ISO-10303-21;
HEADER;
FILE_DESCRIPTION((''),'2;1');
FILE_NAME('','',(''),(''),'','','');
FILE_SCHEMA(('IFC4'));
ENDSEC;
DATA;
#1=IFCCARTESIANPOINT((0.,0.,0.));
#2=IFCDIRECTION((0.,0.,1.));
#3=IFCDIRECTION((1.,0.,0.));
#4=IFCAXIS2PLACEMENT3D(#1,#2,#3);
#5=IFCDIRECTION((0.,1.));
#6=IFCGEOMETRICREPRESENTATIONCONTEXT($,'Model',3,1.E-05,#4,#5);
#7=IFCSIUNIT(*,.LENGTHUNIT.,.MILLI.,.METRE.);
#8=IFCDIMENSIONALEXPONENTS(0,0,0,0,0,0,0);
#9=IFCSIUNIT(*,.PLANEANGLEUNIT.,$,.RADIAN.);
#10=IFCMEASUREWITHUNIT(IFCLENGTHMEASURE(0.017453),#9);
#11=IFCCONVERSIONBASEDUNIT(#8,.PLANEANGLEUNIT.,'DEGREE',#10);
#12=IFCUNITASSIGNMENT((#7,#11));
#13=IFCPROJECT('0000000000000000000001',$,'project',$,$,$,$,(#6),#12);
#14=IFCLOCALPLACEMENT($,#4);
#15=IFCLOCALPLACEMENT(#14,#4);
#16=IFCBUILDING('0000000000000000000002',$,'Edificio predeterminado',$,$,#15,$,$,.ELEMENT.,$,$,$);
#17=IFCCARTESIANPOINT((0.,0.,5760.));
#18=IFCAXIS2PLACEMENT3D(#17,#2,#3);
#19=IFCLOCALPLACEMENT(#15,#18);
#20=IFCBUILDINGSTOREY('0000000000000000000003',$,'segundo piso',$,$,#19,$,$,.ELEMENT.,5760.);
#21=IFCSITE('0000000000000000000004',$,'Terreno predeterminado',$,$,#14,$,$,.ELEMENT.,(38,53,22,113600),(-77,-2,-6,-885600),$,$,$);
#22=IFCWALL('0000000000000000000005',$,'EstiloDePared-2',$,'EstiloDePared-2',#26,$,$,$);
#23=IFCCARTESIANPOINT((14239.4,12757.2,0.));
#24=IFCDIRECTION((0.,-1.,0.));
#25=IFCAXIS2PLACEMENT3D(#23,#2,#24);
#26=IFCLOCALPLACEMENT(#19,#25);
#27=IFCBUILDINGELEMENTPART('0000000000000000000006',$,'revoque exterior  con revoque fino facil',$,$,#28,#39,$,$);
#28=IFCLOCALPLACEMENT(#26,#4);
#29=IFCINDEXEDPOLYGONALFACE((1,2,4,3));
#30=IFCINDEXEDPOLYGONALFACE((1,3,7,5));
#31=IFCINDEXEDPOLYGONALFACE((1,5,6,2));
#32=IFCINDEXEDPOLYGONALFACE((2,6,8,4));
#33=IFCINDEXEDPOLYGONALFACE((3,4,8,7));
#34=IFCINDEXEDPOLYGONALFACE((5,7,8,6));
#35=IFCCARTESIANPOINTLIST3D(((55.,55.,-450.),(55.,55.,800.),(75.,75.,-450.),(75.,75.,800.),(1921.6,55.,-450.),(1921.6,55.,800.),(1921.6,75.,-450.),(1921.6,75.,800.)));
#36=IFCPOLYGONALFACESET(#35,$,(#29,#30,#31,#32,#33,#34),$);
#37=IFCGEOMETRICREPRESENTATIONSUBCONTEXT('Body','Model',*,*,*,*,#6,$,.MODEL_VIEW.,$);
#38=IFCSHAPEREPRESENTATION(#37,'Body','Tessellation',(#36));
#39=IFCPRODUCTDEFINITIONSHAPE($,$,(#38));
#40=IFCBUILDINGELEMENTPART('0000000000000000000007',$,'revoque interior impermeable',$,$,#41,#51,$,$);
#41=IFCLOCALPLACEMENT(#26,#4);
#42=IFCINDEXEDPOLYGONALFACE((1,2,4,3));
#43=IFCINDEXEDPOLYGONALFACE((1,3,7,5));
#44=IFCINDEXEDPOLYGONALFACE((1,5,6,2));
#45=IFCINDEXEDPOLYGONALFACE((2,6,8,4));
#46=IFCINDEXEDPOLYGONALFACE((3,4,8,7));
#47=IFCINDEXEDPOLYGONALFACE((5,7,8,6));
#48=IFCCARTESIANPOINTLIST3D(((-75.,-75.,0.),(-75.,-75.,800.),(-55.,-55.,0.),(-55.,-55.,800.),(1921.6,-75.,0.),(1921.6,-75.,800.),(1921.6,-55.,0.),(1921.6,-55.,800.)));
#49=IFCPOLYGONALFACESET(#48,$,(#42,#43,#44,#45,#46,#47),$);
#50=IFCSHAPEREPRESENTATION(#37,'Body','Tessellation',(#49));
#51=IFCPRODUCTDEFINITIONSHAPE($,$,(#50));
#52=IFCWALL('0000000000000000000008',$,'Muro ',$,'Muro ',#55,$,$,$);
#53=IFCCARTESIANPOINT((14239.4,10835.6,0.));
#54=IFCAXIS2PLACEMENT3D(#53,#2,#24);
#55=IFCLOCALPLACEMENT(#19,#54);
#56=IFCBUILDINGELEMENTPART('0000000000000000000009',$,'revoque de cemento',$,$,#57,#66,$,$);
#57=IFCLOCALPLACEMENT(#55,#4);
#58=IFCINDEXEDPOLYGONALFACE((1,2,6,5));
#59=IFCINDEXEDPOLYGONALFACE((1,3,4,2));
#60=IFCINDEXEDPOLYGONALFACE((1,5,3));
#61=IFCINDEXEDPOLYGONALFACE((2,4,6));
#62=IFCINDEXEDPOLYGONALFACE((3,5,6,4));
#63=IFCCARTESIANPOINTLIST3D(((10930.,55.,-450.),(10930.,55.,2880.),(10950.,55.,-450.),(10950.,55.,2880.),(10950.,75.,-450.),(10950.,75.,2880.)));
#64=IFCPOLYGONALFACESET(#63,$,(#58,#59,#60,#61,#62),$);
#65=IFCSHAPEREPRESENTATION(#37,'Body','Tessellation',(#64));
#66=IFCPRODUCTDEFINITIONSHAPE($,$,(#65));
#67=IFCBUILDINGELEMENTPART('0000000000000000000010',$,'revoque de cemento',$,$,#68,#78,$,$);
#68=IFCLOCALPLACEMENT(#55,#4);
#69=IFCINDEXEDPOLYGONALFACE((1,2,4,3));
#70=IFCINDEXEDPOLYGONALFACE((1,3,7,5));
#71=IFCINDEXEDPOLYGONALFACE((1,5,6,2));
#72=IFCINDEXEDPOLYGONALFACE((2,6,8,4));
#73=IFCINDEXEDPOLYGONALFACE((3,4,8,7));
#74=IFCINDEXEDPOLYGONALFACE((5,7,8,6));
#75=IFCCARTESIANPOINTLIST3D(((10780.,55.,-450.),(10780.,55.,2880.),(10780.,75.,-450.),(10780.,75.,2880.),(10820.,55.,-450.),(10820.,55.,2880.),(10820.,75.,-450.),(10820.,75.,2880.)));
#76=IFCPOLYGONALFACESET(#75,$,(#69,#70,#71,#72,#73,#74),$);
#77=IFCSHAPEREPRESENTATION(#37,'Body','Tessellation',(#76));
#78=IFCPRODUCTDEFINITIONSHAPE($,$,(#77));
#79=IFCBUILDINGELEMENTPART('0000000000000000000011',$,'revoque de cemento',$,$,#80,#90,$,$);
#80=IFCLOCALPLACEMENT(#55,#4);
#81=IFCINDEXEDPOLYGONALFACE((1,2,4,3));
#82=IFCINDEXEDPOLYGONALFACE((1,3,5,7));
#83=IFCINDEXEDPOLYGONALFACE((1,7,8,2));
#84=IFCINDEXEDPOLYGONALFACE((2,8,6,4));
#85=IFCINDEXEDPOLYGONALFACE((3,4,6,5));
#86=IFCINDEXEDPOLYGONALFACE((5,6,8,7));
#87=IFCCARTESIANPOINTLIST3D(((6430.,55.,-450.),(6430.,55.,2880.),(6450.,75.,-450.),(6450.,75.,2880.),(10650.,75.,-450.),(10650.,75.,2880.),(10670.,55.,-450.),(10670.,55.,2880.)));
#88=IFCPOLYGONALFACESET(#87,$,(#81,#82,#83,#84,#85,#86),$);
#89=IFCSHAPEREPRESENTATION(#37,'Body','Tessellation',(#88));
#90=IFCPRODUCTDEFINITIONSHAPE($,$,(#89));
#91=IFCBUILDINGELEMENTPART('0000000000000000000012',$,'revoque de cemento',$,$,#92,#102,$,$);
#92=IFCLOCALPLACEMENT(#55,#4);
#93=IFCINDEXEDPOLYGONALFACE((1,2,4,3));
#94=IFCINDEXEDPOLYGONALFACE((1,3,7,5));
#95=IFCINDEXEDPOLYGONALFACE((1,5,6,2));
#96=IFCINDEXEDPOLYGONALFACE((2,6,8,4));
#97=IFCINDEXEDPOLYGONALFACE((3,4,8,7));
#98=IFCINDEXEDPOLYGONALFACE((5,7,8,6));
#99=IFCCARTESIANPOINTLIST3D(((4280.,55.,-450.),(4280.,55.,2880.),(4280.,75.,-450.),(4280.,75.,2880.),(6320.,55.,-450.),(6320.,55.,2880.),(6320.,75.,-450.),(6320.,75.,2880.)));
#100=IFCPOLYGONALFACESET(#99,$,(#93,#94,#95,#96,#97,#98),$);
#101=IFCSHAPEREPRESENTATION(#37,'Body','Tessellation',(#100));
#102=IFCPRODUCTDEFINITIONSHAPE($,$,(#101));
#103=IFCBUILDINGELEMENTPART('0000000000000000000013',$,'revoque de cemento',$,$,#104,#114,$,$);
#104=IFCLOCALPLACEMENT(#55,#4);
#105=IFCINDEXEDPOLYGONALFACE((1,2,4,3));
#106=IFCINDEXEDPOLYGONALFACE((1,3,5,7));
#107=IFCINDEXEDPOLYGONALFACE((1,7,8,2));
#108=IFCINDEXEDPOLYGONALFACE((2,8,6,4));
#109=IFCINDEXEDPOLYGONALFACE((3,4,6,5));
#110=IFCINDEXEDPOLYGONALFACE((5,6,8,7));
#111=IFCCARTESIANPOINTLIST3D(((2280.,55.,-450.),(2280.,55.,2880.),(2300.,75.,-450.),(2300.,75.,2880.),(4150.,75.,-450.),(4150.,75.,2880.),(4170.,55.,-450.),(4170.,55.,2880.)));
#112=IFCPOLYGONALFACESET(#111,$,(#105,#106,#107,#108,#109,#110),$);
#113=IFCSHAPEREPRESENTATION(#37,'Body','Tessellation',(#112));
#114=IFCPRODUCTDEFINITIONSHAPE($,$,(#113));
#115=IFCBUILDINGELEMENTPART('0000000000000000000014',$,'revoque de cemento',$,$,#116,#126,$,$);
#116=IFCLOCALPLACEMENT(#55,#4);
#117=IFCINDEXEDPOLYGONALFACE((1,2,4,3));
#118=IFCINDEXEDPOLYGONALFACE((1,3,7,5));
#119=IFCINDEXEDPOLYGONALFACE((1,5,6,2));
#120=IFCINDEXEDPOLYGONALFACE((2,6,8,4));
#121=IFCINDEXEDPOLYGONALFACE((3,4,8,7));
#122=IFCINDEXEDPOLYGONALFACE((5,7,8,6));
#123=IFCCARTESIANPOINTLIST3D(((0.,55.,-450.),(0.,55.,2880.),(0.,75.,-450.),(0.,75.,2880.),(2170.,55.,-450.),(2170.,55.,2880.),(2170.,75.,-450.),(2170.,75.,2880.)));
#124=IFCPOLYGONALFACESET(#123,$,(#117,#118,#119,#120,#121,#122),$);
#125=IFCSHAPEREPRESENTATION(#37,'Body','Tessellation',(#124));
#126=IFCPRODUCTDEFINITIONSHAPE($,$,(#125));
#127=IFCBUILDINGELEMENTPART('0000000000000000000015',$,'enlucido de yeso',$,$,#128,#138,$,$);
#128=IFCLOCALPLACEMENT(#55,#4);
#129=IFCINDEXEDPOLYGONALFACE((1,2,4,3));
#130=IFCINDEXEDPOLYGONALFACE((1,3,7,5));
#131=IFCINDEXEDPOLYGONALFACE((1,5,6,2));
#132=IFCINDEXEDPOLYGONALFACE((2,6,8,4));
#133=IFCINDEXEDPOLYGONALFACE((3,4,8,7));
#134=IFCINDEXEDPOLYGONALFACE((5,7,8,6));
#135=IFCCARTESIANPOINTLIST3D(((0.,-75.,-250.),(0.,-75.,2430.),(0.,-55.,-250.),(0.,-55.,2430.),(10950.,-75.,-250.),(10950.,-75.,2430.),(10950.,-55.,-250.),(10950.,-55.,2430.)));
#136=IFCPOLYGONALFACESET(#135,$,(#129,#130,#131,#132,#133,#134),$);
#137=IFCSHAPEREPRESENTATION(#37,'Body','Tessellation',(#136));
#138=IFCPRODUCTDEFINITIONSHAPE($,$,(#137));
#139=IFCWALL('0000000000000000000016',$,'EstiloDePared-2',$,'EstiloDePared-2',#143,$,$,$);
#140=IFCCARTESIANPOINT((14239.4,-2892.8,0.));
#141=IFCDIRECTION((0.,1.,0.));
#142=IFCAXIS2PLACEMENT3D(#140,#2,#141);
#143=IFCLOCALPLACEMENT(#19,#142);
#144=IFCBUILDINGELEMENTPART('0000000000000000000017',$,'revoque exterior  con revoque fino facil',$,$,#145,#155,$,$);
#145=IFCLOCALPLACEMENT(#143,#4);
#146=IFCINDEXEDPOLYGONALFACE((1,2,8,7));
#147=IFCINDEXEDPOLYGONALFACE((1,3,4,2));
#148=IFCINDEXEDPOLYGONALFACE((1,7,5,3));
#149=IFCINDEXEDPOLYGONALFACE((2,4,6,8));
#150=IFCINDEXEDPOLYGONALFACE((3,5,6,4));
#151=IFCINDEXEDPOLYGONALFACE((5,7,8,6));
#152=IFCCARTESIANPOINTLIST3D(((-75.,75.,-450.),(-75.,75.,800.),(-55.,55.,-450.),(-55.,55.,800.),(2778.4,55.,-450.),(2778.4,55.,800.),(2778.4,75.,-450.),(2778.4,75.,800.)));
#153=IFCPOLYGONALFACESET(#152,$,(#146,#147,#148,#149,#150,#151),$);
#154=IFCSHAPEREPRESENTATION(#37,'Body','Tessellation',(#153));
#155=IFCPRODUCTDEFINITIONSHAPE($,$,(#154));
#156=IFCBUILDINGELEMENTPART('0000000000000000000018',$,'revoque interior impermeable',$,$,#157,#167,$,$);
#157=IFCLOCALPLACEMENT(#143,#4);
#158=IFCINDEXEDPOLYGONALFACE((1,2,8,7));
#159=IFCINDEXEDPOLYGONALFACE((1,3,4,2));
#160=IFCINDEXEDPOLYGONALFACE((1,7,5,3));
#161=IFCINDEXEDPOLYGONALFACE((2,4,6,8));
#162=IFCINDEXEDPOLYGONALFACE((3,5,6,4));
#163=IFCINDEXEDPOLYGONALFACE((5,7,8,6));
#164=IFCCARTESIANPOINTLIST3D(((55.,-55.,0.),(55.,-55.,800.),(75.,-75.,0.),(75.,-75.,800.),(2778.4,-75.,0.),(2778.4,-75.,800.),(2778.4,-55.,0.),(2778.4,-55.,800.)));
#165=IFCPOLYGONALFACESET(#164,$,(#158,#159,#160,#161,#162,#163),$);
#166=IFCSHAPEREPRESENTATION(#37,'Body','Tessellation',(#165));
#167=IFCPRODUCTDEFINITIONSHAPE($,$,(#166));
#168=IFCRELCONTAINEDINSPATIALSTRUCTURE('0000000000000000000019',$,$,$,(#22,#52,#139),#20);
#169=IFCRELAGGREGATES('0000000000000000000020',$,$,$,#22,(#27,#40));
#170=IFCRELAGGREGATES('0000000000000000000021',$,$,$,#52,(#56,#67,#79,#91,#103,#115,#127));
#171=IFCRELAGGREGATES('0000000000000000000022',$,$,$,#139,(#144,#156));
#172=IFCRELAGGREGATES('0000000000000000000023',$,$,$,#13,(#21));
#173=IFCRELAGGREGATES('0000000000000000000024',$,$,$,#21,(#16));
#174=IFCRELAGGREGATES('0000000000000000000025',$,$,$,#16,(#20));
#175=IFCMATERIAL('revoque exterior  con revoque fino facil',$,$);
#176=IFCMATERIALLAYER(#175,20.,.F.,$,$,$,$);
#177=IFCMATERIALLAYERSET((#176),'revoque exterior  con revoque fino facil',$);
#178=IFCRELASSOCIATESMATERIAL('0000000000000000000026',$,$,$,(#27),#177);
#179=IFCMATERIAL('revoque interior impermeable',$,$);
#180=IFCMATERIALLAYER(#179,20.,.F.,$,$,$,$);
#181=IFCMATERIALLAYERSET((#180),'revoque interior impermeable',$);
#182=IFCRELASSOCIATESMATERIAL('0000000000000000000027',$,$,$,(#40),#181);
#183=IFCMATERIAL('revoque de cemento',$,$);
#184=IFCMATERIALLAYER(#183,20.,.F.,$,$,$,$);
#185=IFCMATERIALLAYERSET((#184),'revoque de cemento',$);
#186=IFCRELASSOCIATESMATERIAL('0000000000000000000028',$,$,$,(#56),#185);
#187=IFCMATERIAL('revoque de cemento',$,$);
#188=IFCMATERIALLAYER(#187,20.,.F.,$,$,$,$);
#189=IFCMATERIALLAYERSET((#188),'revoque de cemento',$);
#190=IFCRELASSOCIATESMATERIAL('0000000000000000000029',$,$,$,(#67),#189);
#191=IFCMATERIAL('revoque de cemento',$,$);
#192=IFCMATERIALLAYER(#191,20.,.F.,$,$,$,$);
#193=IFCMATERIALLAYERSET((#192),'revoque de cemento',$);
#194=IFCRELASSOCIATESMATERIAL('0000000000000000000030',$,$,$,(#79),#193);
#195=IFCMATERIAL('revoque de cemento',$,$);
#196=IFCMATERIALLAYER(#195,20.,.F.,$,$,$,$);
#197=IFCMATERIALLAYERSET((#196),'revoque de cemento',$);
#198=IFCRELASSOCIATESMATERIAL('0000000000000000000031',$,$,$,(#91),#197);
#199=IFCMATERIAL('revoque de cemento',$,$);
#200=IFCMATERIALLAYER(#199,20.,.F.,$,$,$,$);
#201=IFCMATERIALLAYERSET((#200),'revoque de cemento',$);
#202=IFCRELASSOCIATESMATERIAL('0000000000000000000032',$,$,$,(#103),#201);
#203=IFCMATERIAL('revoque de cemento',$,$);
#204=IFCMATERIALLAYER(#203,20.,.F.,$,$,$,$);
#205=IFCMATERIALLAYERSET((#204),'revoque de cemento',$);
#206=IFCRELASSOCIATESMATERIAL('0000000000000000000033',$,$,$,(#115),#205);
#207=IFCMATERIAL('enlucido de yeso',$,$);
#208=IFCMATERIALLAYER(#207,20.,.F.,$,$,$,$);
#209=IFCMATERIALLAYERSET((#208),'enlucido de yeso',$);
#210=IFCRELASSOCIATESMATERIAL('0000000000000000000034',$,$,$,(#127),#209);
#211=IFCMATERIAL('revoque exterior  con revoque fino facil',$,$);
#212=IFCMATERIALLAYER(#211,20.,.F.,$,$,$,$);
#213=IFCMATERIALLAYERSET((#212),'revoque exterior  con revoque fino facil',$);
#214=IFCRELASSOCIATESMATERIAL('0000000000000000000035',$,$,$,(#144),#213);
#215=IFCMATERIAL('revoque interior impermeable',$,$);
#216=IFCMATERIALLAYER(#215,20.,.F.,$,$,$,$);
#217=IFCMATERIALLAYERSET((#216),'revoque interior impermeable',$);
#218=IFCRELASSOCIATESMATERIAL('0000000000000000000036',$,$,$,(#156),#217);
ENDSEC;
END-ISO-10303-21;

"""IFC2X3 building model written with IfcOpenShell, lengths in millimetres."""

from ifc_helpers import new_model, entity, si_unit, converted_unit, direction, frame, origin_with_axes, place, context, subcontext, project, spatial, polyline, outline, extrude, material, layer, layer_set, layer_usage, element, aggregate, save


model = new_model("IFC2X3")

# Units and contexts
model_context = context("Model", 3, precision=1e-05, world=origin_with_axes(), true_north=direction((0.0, 1.0)))
body_context = subcontext(model_context, "Body", "Model", "MODEL_VIEW")
ifc_project = project(units=[si_unit("LENGTHUNIT", "METRE", prefix="MILLI"), converted_unit("PLANEANGLEUNIT", "DEGREE", entity("IfcLengthMeasure", 0.017453), si_unit("PLANEANGLEUNIT", "RADIAN"), dimensions=[0, 0, 0, 0, 0, 0, 0])], contexts=[model_context])

# Site, building, storey
site_placement = place(None, origin_with_axes())
site = spatial("IfcSite", under=ifc_project, at=site_placement, Name="Terreno predeterminado", CompositionType="ELEMENT", RefLatitude=(38, 53, 22, 113600), RefLongitude=(-77, -2, -6, -885600))
building_placement = place(site_placement, origin_with_axes())
building = spatial("IfcBuilding", under=site, at=building_placement, Name="Edificio predeterminado", CompositionType="ELEMENT")
storey_placement = place(building_placement, frame((0.0, 0.0, 5760.0), z_axis=(0.0, 0.0, 1.0), x_axis=(1.0, 0.0, 0.0)))
storey = spatial("IfcBuildingStorey", under=building, at=storey_placement, Name="segundo piso", CompositionType="ELEMENT", Elevation=5760.0)

# Walls, building element parts
wall_1_placement = place(storey_placement, frame((14239.4, 12757.2, 0.0), z_axis=(0.0, 0.0, 1.0), x_axis=(0.0, -1.0, 0.0)))
wall_1 = element("IfcWall", 1, at=wall_1_placement, inside=storey, Name="EstiloDePared-2", ObjectType="EstiloDePared-2")
ifc_material_1 = material(Name="revoque exterior  con revoque fino facil")
ifc_layer_1 = layer(ifc_material_1, 20.0, ventilated=False)
ifc_layer_set_1 = layer_set([ifc_layer_1], Name="revoque exterior  con revoque fino facil")
ifc_layer_usage_1 = layer_usage(ifc_layer_set_1, "AXIS2", "NEGATIVE", -75.0)
building_element_part_1_placement = place(wall_1_placement, origin_with_axes())
building_element_part_1 = element("IfcBuildingElementPart", 2, at=building_element_part_1_placement, material=ifc_layer_usage_1, Name="revoque exterior  con revoque fino facil", context=body_context, shape_type="SweptSolid", body=[
    extrude(outline(polyline([(1921.6, 75.0), (1921.6, 55.0), (55.0, 55.0), (75.0, 75.0), (1921.6, 75.0)])), frame((0.0, 0.0, -450.0), z_axis=(0.0, 0.0, 1.0), x_axis=(1.0, 0.0, 0.0)), (0.0, 0.0, 1.0), 1250.0),
])
ifc_material_2 = material(Name="revoque interior impermeable")
ifc_layer_2 = layer(ifc_material_2, 20.0, ventilated=False)
ifc_layer_set_2 = layer_set([ifc_layer_2], Name="revoque interior impermeable")
ifc_layer_usage_2 = layer_usage(ifc_layer_set_2, "AXIS2", "NEGATIVE", 55.0)
building_element_part_2_placement = place(wall_1_placement, origin_with_axes())
building_element_part_2 = element("IfcBuildingElementPart", 3, at=building_element_part_2_placement, material=ifc_layer_usage_2, Name="revoque interior impermeable", context=body_context, shape_type="SweptSolid", body=[
    extrude(outline(polyline([(1921.6, -55.0), (1921.6, -75.0), (-75.0, -75.0), (-55.0, -55.0), (1921.6, -55.0)])), origin_with_axes(), (0.0, 0.0, 1.0), 800.0),
])
aggregate(wall_1, [building_element_part_1, building_element_part_2])
wall_2_placement = place(storey_placement, frame((14239.4, 10835.6, 0.0), z_axis=(0.0, 0.0, 1.0), x_axis=(0.0, -1.0, 0.0)))
wall_2 = element("IfcWall", 4, at=wall_2_placement, inside=storey, Name="Muro ", ObjectType="Muro ")
ifc_material_3 = material(Name="revoque de cemento")
ifc_layer_3 = layer(ifc_material_3, 20.0, ventilated=False)
ifc_layer_set_3 = layer_set([ifc_layer_3], Name="revoque de cemento")
ifc_layer_usage_3 = layer_usage(ifc_layer_set_3, "AXIS2", "NEGATIVE", -75.0)
building_element_part_3_placement = place(wall_2_placement, origin_with_axes())
building_element_part_3 = element("IfcBuildingElementPart", 5, at=building_element_part_3_placement, material=ifc_layer_usage_3, Name="revoque de cemento", context=body_context, shape_type="SweptSolid", body=[
    extrude(outline(polyline([(10950.0, 75.0), (10950.0, 55.0), (10930.0, 55.0), (10950.0, 75.0)])), frame((0.0, 0.0, -450.0), z_axis=(0.0, 0.0, 1.0), x_axis=(1.0, 0.0, 0.0)), (0.0, 0.0, 1.0), 3330.0),
])
ifc_material_4 = material(Name="revoque de cemento")
ifc_layer_4 = layer(ifc_material_4, 20.0, ventilated=False)
ifc_layer_set_4 = layer_set([ifc_layer_4], Name="revoque de cemento")
ifc_layer_usage_4 = layer_usage(ifc_layer_set_4, "AXIS2", "NEGATIVE", -75.0)
building_element_part_4_placement = place(wall_2_placement, origin_with_axes())
building_element_part_4 = element("IfcBuildingElementPart", 6, at=building_element_part_4_placement, material=ifc_layer_usage_4, Name="revoque de cemento", context=body_context, shape_type="SweptSolid", body=[
    extrude(outline(polyline([(10820.0, 75.0), (10820.0, 55.0), (10780.0, 55.0), (10780.0, 75.0), (10820.0, 75.0)])), frame((0.0, 0.0, -450.0), z_axis=(0.0, 0.0, 1.0), x_axis=(1.0, 0.0, 0.0)), (0.0, 0.0, 1.0), 3330.0),
])
ifc_material_5 = material(Name="revoque de cemento")
ifc_layer_5 = layer(ifc_material_5, 20.0, ventilated=False)
ifc_layer_set_5 = layer_set([ifc_layer_5], Name="revoque de cemento")
ifc_layer_usage_5 = layer_usage(ifc_layer_set_5, "AXIS2", "NEGATIVE", -75.0)
building_element_part_5_placement = place(wall_2_placement, origin_with_axes())
building_element_part_5 = element("IfcBuildingElementPart", 7, at=building_element_part_5_placement, material=ifc_layer_usage_5, Name="revoque de cemento", context=body_context, shape_type="SweptSolid", body=[
    extrude(outline(polyline([(10650.0, 75.0), (10670.0, 55.0), (6430.0, 55.0), (6450.0, 75.0), (10650.0, 75.0)])), frame((0.0, 0.0, -450.0), z_axis=(0.0, 0.0, 1.0), x_axis=(1.0, 0.0, 0.0)), (0.0, 0.0, 1.0), 3330.0),
])
ifc_material_6 = material(Name="revoque de cemento")
ifc_layer_6 = layer(ifc_material_6, 20.0, ventilated=False)
ifc_layer_set_6 = layer_set([ifc_layer_6], Name="revoque de cemento")
ifc_layer_usage_6 = layer_usage(ifc_layer_set_6, "AXIS2", "NEGATIVE", -75.0)
building_element_part_6_placement = place(wall_2_placement, origin_with_axes())
building_element_part_6 = element("IfcBuildingElementPart", 8, at=building_element_part_6_placement, material=ifc_layer_usage_6, Name="revoque de cemento", context=body_context, shape_type="SweptSolid", body=[
    extrude(outline(polyline([(4280.0, 75.0), (6320.0, 75.0), (6320.0, 55.0), (4280.0, 55.0), (4280.0, 75.0)])), frame((0.0, 0.0, -450.0), z_axis=(0.0, 0.0, 1.0), x_axis=(1.0, 0.0, 0.0)), (0.0, 0.0, 1.0), 3330.0),
])
ifc_material_7 = material(Name="revoque de cemento")
ifc_layer_7 = layer(ifc_material_7, 20.0, ventilated=False)
ifc_layer_set_7 = layer_set([ifc_layer_7], Name="revoque de cemento")
ifc_layer_usage_7 = layer_usage(ifc_layer_set_7, "AXIS2", "NEGATIVE", -75.0)
building_element_part_7_placement = place(wall_2_placement, origin_with_axes())
building_element_part_7 = element("IfcBuildingElementPart", 9, at=building_element_part_7_placement, material=ifc_layer_usage_7, Name="revoque de cemento", context=body_context, shape_type="SweptSolid", body=[
    extrude(outline(polyline([(4150.0, 75.0), (4170.0, 55.0), (2280.0, 55.0), (2300.0, 75.0), (4150.0, 75.0)])), frame((0.0, 0.0, -450.0), z_axis=(0.0, 0.0, 1.0), x_axis=(1.0, 0.0, 0.0)), (0.0, 0.0, 1.0), 3330.0),
])
ifc_material_8 = material(Name="revoque de cemento")
ifc_layer_8 = layer(ifc_material_8, 20.0, ventilated=False)
ifc_layer_set_8 = layer_set([ifc_layer_8], Name="revoque de cemento")
ifc_layer_usage_8 = layer_usage(ifc_layer_set_8, "AXIS2", "NEGATIVE", -75.0)
building_element_part_8_placement = place(wall_2_placement, origin_with_axes())
building_element_part_8 = element("IfcBuildingElementPart", 10, at=building_element_part_8_placement, material=ifc_layer_usage_8, Name="revoque de cemento", context=body_context, shape_type="SweptSolid", body=[
    extrude(outline(polyline([(2170.0, 75.0), (2170.0, 55.0), (0.0, 55.0), (0.0, 75.0), (2170.0, 75.0)])), frame((0.0, 0.0, -450.0), z_axis=(0.0, 0.0, 1.0), x_axis=(1.0, 0.0, 0.0)), (0.0, 0.0, 1.0), 3330.0),
])
ifc_material_9 = material(Name="enlucido de yeso")
ifc_layer_9 = layer(ifc_material_9, 20.0, ventilated=False)
ifc_layer_set_9 = layer_set([ifc_layer_9], Name="enlucido de yeso")
ifc_layer_usage_9 = layer_usage(ifc_layer_set_9, "AXIS2", "NEGATIVE", 55.0)
building_element_part_9_placement = place(wall_2_placement, origin_with_axes())
building_element_part_9 = element("IfcBuildingElementPart", 11, at=building_element_part_9_placement, material=ifc_layer_usage_9, Name="enlucido de yeso", context=body_context, shape_type="SweptSolid", body=[
    extrude(outline(polyline([(10950.0, -55.0), (10950.0, -75.0), (0.0, -75.0), (0.0, -55.0), (10950.0, -55.0)])), frame((0.0, 0.0, -250.0), z_axis=(0.0, 0.0, 1.0), x_axis=(1.0, 0.0, 0.0)), (0.0, 0.0, 1.0), 2680.0),
])
aggregate(wall_2, [building_element_part_3, building_element_part_4, building_element_part_5, building_element_part_6, building_element_part_7, building_element_part_8, building_element_part_9])
wall_3_placement = place(storey_placement, frame((14239.4, -2892.8, 0.0), z_axis=(0.0, 0.0, 1.0), x_axis=(0.0, 1.0, 0.0)))
wall_3 = element("IfcWall", 12, at=wall_3_placement, inside=storey, Name="EstiloDePared-2", ObjectType="EstiloDePared-2")
ifc_material_10 = material(Name="revoque exterior  con revoque fino facil")
ifc_layer_10 = layer(ifc_material_10, 20.0, ventilated=False)
ifc_layer_set_10 = layer_set([ifc_layer_10], Name="revoque exterior  con revoque fino facil")
ifc_layer_usage_10 = layer_usage(ifc_layer_set_10, "AXIS2", "NEGATIVE", -75.0)
building_element_part_10_placement = place(wall_3_placement, origin_with_axes())
building_element_part_10 = element("IfcBuildingElementPart", 13, at=building_element_part_10_placement, material=ifc_layer_usage_10, Name="revoque exterior  con revoque fino facil", context=body_context, shape_type="SweptSolid", body=[
    extrude(outline(polyline([(2778.4, 75.0), (2778.4, 55.0), (-55.0, 55.0), (-75.0, 75.0), (2778.4, 75.0)])), frame((0.0, 0.0, -450.0), z_axis=(0.0, 0.0, 1.0), x_axis=(1.0, 0.0, 0.0)), (0.0, 0.0, 1.0), 1250.0),
])
ifc_material_11 = material(Name="revoque interior impermeable")
ifc_layer_11 = layer(ifc_material_11, 20.0, ventilated=False)
ifc_layer_set_11 = layer_set([ifc_layer_11], Name="revoque interior impermeable")
ifc_layer_usage_11 = layer_usage(ifc_layer_set_11, "AXIS2", "NEGATIVE", 55.0)
building_element_part_11_placement = place(wall_3_placement, origin_with_axes())
building_element_part_11 = element("IfcBuildingElementPart", 14, at=building_element_part_11_placement, material=ifc_layer_usage_11, Name="revoque interior impermeable", context=body_context, shape_type="SweptSolid", body=[
    extrude(outline(polyline([(2778.4, -55.0), (2778.4, -75.0), (75.0, -75.0), (55.0, -55.0), (2778.4, -55.0)])), origin_with_axes(), (0.0, 0.0, 1.0), 800.0),
])
aggregate(wall_3, [building_element_part_10, building_element_part_11])

save(model, "model.ifc")
